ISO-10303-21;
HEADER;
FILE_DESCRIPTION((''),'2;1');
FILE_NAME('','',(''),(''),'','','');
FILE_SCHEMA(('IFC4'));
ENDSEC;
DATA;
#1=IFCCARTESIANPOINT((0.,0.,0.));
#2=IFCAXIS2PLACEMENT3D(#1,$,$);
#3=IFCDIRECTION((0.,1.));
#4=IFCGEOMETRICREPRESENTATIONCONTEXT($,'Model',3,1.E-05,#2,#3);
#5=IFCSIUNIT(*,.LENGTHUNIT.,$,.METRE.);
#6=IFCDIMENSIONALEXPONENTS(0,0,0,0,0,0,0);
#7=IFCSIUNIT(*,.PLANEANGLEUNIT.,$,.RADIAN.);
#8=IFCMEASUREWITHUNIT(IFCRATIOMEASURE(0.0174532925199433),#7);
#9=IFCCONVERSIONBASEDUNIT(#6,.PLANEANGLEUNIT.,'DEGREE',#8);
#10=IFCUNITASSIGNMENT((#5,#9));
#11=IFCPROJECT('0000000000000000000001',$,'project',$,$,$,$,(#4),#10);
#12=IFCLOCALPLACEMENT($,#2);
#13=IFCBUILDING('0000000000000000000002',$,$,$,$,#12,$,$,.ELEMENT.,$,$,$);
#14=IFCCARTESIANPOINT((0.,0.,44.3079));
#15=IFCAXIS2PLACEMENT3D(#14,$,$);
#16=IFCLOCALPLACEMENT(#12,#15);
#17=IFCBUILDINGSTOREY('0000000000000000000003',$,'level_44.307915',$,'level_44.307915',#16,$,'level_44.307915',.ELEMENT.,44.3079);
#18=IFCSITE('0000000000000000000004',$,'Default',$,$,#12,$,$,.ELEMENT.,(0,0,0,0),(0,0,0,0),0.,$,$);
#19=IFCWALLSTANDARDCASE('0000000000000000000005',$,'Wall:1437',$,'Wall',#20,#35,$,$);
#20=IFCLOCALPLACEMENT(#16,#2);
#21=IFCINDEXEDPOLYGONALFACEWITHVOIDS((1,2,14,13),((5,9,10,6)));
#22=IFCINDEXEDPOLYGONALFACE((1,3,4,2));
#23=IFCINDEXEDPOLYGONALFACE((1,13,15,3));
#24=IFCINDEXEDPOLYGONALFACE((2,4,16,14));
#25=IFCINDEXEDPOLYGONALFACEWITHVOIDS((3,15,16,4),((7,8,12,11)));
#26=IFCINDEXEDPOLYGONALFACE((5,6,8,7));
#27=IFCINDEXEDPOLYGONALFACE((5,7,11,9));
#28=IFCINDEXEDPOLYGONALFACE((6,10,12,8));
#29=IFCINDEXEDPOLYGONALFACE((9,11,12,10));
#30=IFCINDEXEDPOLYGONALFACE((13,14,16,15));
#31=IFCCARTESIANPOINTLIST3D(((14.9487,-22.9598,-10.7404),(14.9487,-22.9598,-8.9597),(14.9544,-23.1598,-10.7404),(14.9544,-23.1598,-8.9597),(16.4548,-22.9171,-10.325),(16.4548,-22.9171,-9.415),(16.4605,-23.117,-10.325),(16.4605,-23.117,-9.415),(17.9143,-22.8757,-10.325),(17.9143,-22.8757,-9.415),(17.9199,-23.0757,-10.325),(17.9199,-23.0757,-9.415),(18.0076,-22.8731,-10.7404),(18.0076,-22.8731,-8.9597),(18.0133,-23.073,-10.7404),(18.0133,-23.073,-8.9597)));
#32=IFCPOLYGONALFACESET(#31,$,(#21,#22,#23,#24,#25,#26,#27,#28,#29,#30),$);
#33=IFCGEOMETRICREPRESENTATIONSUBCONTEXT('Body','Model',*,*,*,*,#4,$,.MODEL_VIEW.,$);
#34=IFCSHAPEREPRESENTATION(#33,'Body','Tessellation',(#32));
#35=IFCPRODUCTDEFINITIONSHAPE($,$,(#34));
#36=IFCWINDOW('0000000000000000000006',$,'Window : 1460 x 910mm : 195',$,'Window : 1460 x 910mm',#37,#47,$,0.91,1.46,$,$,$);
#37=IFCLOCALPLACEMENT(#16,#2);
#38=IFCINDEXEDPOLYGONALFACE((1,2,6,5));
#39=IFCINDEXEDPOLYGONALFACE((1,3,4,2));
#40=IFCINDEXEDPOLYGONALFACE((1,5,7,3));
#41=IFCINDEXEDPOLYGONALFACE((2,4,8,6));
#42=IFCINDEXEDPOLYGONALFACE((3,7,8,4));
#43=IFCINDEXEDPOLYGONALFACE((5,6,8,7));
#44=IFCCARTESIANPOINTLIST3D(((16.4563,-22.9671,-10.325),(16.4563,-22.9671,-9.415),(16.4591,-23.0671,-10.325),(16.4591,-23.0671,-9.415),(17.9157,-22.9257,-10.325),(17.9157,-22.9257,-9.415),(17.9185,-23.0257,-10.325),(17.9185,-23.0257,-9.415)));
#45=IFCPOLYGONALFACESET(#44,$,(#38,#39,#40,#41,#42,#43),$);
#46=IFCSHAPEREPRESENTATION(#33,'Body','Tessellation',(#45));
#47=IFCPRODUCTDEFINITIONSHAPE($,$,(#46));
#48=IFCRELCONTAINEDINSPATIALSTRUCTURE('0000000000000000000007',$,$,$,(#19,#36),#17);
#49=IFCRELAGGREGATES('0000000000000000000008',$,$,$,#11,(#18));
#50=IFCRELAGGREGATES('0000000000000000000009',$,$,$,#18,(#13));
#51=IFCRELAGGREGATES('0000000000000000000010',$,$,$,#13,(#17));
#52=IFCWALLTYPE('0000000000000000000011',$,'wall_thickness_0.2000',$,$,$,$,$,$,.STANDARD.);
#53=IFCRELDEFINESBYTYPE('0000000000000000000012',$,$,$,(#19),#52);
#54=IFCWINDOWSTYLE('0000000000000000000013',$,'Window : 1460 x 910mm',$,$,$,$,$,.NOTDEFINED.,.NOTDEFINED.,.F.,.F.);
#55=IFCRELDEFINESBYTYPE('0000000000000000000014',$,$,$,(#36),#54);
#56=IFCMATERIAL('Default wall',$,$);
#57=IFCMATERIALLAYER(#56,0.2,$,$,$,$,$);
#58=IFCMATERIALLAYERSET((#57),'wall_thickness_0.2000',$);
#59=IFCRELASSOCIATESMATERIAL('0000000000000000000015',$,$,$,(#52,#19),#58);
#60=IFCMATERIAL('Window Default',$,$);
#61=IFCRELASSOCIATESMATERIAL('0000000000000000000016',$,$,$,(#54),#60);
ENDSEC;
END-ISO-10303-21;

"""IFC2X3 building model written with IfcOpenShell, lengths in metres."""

from ifc_helpers import new_model, entity, si_unit, converted_unit, direction, frame, frame_2d, origin, origin_2d_with_axis, place, context, subcontext, project, spatial, polyline, rectangle, outline, extrude, source, transform, mapped, material, layer, layer_set, layer_usage, type_object, type_shapes, element, fill, save


model = new_model("IFC2X3")

# Units and contexts
model_context = context("Model", 3, precision=1e-05, world=origin(), true_north=direction((0.0, 1.0)))
body_context = subcontext(model_context, "Body", "Model", "MODEL_VIEW")
ifc_project = project(units=[si_unit("LENGTHUNIT", "METRE"), converted_unit("PLANEANGLEUNIT", "DEGREE", entity("IfcRatioMeasure", 0.0174532925199433), si_unit("PLANEANGLEUNIT", "RADIAN"), dimensions=[0, 0, 0, 0, 0, 0, 0])], contexts=[model_context])

# Site, building, storey
placement_1 = place(None, origin())
site = spatial("IfcSite", under=ifc_project, at=placement_1, Name="Default", CompositionType="ELEMENT", RefLatitude=(0, 0, 0, 0), RefLongitude=(0, 0, 0, 0), RefElevation=0.0)
building = spatial("IfcBuilding", under=site, at=placement_1, CompositionType="ELEMENT")
storey_placement = place(placement_1, frame((0.0, 0.0, 44.3079)))
storey = spatial("IfcBuildingStorey", under=building, at=storey_placement, Name="level_44.307915", ObjectType="level_44.307915", LongName="level_44.307915", CompositionType="ELEMENT", Elevation=44.3079)

# Wall, opening, window
ifc_material_1 = material(Name="Default wall")
ifc_layer = layer(ifc_material_1, 0.2)
ifc_layer_set = layer_set([ifc_layer], Name="wall_thickness_0.2000")
ifc_layer_usage = layer_usage(ifc_layer_set, "AXIS2", "POSITIVE", -0.1)
wall_type = type_object("IfcWallType", Name="wall_thickness_0.2000", PredefinedType="STANDARD", material=ifc_layer_set)
placement_2 = place(placement_1, frame((0.0, 0.0, 33.5675)))
wall_1_placement = place(placement_2, frame((14.9515, -23.0598, 0.0), z_axis=(0.0, 0.0, 1.0), x_axis=(0.999598, 0.028349, 0.0)))
wall_1 = element("IfcWallStandardCase", 1, at=wall_1_placement, inside=storey, type_object=wall_type, material=ifc_layer_usage, Name="Wall:1437", ObjectType="Wall", context=body_context, shape_type="SweptSolid", body=[
    extrude(outline(polyline([(3.0602, -0.1), (3.0602, 0.1), (0.0, 0.1), (0.0, -0.1), (3.0602, -0.1)])), origin(), (0.0, 0.0, 1.0), 1.7807),
])
opening_1_placement = place(wall_1_placement, frame((1.5068, -0.1, 0.4154)))
opening_1 = element("IfcOpeningElement", 2, at=opening_1_placement, cuts=wall_1, ObjectType="Opening", context=body_context, shape_type="SweptSolid", body=[
    extrude(rectangle(XDim=1.46, YDim=0.91, at=frame_2d((0.455, 0.73), x_axis=(0.0, 1.0))), frame((0.0, 0.0, 0.0), z_axis=(0.0, 1.0, 0.0), x_axis=(0.0, 0.0, 1.0)), (0.0, 0.0, 1.0), 0.2),
])
ifc_material_2 = material(Name="Window Default")
window_style_1 = type_object("IfcWindowStyle", Name="Window : 1460 x 910mm", ConstructionType="NOTDEFINED", OperationType="NOTDEFINED", ParameterTakesPrecedence=False, Sizeable=False, material=ifc_material_2)
shared_shape_1 = source(origin(), body_context, "Body", "SweptSolid", [
    extrude(rectangle(XDim=0.1, YDim=1.46, at=origin_2d_with_axis()), frame((0.73, 0.1, 0.0), z_axis=(0.0, 0.0, 1.0), x_axis=(0.0, 1.0, 0.0)), (0.0, 0.0, 1.0), 0.91),
])
type_shapes(window_style_1, [shared_shape_1])
window_1_placement = place(opening_1_placement, origin())
window_1 = element("IfcWindow", 3, at=window_1_placement, inside=storey, type_object=window_style_1, Name="Window : 1460 x 910mm : 195", ObjectType="Window : 1460 x 910mm", OverallHeight=0.91, OverallWidth=1.46, context=body_context, shape_type="MappedRepresentation", body=[
    mapped(shared_shape_1, transform((0.0, 0.0, 0.0), scale=1.0)),
])
fill(opening_1, window_1)

save(model, "model.ifc")
